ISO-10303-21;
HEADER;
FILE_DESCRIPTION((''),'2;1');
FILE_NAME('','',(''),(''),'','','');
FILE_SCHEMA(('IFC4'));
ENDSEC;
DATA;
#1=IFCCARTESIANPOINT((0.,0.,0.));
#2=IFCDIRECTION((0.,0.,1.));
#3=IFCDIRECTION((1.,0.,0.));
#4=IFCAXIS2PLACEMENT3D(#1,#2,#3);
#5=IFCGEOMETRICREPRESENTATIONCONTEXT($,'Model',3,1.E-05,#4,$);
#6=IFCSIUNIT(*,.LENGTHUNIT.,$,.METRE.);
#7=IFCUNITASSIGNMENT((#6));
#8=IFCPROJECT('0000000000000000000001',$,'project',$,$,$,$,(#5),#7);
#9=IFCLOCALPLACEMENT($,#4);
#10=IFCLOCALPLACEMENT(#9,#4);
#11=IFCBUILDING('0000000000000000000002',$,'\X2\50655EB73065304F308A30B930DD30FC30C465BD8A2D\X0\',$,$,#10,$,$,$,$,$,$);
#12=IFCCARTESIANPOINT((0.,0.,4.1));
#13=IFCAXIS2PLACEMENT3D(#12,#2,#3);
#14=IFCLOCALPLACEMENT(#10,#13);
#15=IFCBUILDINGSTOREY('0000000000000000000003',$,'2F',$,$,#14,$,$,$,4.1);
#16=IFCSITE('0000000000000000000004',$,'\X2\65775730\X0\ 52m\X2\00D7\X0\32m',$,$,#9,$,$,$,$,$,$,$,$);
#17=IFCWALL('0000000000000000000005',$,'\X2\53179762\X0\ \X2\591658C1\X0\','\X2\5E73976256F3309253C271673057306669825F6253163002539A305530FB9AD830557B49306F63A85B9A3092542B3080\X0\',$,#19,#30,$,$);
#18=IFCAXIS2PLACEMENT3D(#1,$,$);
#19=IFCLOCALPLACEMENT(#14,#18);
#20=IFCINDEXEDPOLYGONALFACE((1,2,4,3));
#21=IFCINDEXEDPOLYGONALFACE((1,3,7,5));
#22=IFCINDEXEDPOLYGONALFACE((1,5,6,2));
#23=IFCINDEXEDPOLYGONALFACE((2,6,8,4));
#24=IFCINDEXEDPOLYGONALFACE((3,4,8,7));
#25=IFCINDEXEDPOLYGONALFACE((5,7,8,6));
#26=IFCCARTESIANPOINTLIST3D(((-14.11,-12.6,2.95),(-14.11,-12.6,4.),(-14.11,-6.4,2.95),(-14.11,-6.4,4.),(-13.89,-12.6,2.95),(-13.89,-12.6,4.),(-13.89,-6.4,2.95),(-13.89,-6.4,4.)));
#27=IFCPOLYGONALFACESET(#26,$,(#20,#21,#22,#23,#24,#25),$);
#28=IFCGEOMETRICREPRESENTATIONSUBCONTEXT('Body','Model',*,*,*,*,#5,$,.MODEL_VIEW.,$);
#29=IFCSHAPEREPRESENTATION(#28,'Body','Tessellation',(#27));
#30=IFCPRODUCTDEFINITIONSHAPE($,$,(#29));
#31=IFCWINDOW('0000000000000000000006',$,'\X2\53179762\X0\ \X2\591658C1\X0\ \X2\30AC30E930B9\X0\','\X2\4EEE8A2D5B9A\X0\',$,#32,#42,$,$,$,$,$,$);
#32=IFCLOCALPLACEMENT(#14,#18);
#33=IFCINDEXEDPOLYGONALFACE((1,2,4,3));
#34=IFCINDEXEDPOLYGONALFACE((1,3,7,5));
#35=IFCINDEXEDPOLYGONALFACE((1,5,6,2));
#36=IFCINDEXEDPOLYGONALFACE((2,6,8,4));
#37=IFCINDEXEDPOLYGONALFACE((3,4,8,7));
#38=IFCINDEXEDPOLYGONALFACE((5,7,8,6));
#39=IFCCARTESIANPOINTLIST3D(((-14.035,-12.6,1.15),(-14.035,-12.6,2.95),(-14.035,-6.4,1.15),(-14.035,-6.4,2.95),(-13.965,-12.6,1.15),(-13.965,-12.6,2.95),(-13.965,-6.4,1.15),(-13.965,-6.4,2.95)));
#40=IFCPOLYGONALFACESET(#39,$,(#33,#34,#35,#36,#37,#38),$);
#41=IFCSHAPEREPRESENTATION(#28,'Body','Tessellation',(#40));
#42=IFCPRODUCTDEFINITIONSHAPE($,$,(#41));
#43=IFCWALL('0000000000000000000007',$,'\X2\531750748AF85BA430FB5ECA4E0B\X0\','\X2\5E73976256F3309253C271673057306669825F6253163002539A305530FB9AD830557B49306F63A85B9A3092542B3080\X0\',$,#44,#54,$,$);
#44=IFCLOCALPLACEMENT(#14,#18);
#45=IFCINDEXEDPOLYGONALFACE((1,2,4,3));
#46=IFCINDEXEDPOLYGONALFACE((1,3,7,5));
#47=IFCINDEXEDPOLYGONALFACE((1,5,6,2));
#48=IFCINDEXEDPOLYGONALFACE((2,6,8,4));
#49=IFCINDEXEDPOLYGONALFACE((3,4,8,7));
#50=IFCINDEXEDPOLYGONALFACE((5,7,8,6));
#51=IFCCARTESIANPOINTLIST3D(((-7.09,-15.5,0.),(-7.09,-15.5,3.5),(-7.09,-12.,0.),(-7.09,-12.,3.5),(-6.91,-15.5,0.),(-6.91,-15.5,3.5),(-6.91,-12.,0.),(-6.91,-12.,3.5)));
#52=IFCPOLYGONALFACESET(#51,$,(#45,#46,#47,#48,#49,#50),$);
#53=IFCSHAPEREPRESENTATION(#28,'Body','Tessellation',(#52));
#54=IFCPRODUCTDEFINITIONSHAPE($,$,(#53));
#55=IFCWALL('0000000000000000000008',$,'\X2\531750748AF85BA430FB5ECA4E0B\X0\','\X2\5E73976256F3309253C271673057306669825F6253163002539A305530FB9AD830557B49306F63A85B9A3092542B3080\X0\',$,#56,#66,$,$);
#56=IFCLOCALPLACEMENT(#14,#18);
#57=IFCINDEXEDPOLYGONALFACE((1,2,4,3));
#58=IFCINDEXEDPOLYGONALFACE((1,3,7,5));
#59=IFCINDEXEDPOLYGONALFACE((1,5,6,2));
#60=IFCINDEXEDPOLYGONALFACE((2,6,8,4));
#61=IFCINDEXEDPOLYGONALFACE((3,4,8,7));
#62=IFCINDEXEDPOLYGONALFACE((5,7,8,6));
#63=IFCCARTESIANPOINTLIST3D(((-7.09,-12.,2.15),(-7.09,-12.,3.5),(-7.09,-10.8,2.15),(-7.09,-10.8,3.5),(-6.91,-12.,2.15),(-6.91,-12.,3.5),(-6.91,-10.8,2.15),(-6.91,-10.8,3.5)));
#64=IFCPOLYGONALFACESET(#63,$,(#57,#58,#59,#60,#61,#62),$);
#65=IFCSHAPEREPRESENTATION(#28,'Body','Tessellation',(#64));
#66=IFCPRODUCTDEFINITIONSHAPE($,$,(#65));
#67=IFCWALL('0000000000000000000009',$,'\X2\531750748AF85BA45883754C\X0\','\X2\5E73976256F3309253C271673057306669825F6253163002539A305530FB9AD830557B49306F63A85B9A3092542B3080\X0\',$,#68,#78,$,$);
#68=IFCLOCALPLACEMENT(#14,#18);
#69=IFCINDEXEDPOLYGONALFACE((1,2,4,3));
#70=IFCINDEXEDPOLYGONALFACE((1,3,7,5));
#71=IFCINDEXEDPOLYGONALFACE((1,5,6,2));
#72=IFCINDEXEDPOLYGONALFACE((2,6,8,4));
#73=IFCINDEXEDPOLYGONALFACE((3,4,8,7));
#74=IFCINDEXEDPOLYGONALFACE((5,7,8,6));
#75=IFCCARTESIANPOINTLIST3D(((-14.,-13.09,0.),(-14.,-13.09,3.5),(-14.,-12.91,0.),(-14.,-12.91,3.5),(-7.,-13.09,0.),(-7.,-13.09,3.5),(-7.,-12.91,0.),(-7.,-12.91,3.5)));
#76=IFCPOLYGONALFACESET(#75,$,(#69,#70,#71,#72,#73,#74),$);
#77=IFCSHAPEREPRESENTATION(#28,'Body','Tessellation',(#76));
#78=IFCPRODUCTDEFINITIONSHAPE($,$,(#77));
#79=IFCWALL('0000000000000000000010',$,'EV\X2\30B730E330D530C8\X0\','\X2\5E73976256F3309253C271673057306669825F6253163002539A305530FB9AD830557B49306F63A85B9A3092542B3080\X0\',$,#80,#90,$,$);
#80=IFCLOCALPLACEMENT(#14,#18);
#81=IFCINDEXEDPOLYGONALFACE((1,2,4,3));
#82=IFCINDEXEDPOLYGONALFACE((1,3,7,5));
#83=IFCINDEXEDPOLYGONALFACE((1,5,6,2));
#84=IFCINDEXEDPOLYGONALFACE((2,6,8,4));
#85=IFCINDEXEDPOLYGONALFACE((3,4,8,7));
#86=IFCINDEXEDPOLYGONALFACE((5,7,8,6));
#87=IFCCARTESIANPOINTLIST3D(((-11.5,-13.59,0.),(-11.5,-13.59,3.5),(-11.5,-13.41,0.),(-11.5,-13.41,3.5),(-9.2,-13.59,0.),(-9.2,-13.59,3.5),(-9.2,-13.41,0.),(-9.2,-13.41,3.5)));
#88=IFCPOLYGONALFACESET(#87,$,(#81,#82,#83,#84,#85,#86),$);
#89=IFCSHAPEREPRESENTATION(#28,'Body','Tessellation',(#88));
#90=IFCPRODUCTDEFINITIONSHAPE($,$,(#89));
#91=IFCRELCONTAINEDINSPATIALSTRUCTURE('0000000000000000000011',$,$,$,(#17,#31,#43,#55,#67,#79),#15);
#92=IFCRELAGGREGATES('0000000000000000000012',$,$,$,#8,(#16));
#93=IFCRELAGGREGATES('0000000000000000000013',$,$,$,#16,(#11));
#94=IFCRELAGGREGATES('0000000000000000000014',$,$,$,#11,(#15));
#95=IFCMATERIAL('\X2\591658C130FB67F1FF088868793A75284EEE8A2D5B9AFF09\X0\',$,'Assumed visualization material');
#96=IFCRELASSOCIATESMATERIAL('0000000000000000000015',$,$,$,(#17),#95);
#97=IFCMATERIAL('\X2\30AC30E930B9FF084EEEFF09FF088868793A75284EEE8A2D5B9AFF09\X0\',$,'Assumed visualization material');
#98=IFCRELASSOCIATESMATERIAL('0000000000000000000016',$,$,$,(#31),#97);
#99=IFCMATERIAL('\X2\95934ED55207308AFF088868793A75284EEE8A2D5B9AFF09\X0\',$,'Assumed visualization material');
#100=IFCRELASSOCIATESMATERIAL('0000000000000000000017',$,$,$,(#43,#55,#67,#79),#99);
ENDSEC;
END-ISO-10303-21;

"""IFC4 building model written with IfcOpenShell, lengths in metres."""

from ifc_helpers import new_model, si_unit, frame, origin_with_axes, place, context, subcontext, project, spatial, rectangle, extrude, material, element, save


model = new_model("IFC4")

# Units and contexts
model_context = context("Model", 3, precision=1e-05, world=origin_with_axes())
body_context = subcontext(model_context, "Body", "Model", "MODEL_VIEW")
ifc_project = project(units=[si_unit("LENGTHUNIT", "METRE")], contexts=[model_context])

# Site, building, storey
site_placement = place(None, origin_with_axes())
site = spatial("IfcSite", under=ifc_project, at=site_placement, Name="敷地 52m×32m")
building_placement = place(site_placement, origin_with_axes())
building = spatial("IfcBuilding", under=site, at=building_placement, Name="健康づくりスポーツ施設")
storey_placement = place(building_placement, frame((0.0, 0.0, 4.1), z_axis=(0.0, 0.0, 1.0), x_axis=(1.0, 0.0, 0.0)))
storey = spatial("IfcBuildingStorey", under=building, at=storey_placement, Name="2F", Elevation=4.1)

# Wall
ifc_material_1 = material(Name="外壁・柱（表示用仮設定）", Category="Assumed visualization material")
wall_1_placement = place(storey_placement, frame((-14.0, -9.5, 2.95), z_axis=(0.0, 0.0, 1.0), x_axis=(1.0, 0.0, 0.0)))
element("IfcWall", 1, at=wall_1_placement, inside=storey, material=ifc_material_1, Name="北面 外壁", Description="平面図を参照して概形化。厚さ・高さ等は推定を含む", context=body_context, shape_type="SweptSolid", body=[
    extrude(rectangle(XDim=0.22, YDim=6.2), origin_with_axes(), (0.0, 0.0, 1.0), 1.05),
])

# Window
ifc_material_2 = material(Name="ガラス（仮）（表示用仮設定）", Category="Assumed visualization material")
window_placement = place(storey_placement, frame((-14.0, -9.5, 1.15), z_axis=(0.0, 0.0, 1.0), x_axis=(1.0, 0.0, 0.0)))
element("IfcWindow", 2, at=window_placement, inside=storey, material=ifc_material_2, Name="北面 外壁 ガラス", Description="仮設定", context=body_context, shape_type="SweptSolid", body=[
    extrude(rectangle(XDim=0.07, YDim=6.2), origin_with_axes(), (0.0, 0.0, 1.0), 1.8),
])

# Walls
ifc_material_3 = material(Name="間仕切り（表示用仮設定）", Category="Assumed visualization material")
wall_2_placement = place(storey_placement, frame((-7.0, -13.75, 0.0), z_axis=(0.0, 0.0, 1.0), x_axis=(1.0, 0.0, 0.0)))
element("IfcWall", 3, at=wall_2_placement, inside=storey, material=ifc_material_3, Name="北側諸室・廊下", Description="平面図を参照して概形化。厚さ・高さ等は推定を含む", context=body_context, shape_type="SweptSolid", body=[
    extrude(rectangle(XDim=0.18, YDim=3.5), origin_with_axes(), (0.0, 0.0, 1.0), 3.5),
])
wall_3_placement = place(storey_placement, frame((-7.0, -11.4, 2.15), z_axis=(0.0, 0.0, 1.0), x_axis=(1.0, 0.0, 0.0)))
element("IfcWall", 4, at=wall_3_placement, inside=storey, material=ifc_material_3, Name="北側諸室・廊下", Description="平面図を参照して概形化。厚さ・高さ等は推定を含む", context=body_context, shape_type="SweptSolid", body=[
    extrude(rectangle(XDim=0.18, YDim=1.2), origin_with_axes(), (0.0, 0.0, 1.0), 1.35),
])
wall_4_placement = place(storey_placement, frame((-10.5, -13.0, 0.0), z_axis=(0.0, 0.0, 1.0), x_axis=(1.0, 0.0, 0.0)))
element("IfcWall", 5, at=wall_4_placement, inside=storey, material=ifc_material_3, Name="北側諸室境界", Description="平面図を参照して概形化。厚さ・高さ等は推定を含む", context=body_context, shape_type="SweptSolid", body=[
    extrude(rectangle(XDim=7.0, YDim=0.18), origin_with_axes(), (0.0, 0.0, 1.0), 3.5),
])
wall_5_placement = place(storey_placement, frame((-10.35, -13.5, 0.0), z_axis=(0.0, 0.0, 1.0), x_axis=(1.0, 0.0, 0.0)))
element("IfcWall", 6, at=wall_5_placement, inside=storey, material=ifc_material_3, Name="EVシャフト", Description="平面図を参照して概形化。厚さ・高さ等は推定を含む", context=body_context, shape_type="SweptSolid", body=[
    extrude(rectangle(XDim=2.3, YDim=0.18), origin_with_axes(), (0.0, 0.0, 1.0), 3.5),
])

save(model, "model.ifc")
